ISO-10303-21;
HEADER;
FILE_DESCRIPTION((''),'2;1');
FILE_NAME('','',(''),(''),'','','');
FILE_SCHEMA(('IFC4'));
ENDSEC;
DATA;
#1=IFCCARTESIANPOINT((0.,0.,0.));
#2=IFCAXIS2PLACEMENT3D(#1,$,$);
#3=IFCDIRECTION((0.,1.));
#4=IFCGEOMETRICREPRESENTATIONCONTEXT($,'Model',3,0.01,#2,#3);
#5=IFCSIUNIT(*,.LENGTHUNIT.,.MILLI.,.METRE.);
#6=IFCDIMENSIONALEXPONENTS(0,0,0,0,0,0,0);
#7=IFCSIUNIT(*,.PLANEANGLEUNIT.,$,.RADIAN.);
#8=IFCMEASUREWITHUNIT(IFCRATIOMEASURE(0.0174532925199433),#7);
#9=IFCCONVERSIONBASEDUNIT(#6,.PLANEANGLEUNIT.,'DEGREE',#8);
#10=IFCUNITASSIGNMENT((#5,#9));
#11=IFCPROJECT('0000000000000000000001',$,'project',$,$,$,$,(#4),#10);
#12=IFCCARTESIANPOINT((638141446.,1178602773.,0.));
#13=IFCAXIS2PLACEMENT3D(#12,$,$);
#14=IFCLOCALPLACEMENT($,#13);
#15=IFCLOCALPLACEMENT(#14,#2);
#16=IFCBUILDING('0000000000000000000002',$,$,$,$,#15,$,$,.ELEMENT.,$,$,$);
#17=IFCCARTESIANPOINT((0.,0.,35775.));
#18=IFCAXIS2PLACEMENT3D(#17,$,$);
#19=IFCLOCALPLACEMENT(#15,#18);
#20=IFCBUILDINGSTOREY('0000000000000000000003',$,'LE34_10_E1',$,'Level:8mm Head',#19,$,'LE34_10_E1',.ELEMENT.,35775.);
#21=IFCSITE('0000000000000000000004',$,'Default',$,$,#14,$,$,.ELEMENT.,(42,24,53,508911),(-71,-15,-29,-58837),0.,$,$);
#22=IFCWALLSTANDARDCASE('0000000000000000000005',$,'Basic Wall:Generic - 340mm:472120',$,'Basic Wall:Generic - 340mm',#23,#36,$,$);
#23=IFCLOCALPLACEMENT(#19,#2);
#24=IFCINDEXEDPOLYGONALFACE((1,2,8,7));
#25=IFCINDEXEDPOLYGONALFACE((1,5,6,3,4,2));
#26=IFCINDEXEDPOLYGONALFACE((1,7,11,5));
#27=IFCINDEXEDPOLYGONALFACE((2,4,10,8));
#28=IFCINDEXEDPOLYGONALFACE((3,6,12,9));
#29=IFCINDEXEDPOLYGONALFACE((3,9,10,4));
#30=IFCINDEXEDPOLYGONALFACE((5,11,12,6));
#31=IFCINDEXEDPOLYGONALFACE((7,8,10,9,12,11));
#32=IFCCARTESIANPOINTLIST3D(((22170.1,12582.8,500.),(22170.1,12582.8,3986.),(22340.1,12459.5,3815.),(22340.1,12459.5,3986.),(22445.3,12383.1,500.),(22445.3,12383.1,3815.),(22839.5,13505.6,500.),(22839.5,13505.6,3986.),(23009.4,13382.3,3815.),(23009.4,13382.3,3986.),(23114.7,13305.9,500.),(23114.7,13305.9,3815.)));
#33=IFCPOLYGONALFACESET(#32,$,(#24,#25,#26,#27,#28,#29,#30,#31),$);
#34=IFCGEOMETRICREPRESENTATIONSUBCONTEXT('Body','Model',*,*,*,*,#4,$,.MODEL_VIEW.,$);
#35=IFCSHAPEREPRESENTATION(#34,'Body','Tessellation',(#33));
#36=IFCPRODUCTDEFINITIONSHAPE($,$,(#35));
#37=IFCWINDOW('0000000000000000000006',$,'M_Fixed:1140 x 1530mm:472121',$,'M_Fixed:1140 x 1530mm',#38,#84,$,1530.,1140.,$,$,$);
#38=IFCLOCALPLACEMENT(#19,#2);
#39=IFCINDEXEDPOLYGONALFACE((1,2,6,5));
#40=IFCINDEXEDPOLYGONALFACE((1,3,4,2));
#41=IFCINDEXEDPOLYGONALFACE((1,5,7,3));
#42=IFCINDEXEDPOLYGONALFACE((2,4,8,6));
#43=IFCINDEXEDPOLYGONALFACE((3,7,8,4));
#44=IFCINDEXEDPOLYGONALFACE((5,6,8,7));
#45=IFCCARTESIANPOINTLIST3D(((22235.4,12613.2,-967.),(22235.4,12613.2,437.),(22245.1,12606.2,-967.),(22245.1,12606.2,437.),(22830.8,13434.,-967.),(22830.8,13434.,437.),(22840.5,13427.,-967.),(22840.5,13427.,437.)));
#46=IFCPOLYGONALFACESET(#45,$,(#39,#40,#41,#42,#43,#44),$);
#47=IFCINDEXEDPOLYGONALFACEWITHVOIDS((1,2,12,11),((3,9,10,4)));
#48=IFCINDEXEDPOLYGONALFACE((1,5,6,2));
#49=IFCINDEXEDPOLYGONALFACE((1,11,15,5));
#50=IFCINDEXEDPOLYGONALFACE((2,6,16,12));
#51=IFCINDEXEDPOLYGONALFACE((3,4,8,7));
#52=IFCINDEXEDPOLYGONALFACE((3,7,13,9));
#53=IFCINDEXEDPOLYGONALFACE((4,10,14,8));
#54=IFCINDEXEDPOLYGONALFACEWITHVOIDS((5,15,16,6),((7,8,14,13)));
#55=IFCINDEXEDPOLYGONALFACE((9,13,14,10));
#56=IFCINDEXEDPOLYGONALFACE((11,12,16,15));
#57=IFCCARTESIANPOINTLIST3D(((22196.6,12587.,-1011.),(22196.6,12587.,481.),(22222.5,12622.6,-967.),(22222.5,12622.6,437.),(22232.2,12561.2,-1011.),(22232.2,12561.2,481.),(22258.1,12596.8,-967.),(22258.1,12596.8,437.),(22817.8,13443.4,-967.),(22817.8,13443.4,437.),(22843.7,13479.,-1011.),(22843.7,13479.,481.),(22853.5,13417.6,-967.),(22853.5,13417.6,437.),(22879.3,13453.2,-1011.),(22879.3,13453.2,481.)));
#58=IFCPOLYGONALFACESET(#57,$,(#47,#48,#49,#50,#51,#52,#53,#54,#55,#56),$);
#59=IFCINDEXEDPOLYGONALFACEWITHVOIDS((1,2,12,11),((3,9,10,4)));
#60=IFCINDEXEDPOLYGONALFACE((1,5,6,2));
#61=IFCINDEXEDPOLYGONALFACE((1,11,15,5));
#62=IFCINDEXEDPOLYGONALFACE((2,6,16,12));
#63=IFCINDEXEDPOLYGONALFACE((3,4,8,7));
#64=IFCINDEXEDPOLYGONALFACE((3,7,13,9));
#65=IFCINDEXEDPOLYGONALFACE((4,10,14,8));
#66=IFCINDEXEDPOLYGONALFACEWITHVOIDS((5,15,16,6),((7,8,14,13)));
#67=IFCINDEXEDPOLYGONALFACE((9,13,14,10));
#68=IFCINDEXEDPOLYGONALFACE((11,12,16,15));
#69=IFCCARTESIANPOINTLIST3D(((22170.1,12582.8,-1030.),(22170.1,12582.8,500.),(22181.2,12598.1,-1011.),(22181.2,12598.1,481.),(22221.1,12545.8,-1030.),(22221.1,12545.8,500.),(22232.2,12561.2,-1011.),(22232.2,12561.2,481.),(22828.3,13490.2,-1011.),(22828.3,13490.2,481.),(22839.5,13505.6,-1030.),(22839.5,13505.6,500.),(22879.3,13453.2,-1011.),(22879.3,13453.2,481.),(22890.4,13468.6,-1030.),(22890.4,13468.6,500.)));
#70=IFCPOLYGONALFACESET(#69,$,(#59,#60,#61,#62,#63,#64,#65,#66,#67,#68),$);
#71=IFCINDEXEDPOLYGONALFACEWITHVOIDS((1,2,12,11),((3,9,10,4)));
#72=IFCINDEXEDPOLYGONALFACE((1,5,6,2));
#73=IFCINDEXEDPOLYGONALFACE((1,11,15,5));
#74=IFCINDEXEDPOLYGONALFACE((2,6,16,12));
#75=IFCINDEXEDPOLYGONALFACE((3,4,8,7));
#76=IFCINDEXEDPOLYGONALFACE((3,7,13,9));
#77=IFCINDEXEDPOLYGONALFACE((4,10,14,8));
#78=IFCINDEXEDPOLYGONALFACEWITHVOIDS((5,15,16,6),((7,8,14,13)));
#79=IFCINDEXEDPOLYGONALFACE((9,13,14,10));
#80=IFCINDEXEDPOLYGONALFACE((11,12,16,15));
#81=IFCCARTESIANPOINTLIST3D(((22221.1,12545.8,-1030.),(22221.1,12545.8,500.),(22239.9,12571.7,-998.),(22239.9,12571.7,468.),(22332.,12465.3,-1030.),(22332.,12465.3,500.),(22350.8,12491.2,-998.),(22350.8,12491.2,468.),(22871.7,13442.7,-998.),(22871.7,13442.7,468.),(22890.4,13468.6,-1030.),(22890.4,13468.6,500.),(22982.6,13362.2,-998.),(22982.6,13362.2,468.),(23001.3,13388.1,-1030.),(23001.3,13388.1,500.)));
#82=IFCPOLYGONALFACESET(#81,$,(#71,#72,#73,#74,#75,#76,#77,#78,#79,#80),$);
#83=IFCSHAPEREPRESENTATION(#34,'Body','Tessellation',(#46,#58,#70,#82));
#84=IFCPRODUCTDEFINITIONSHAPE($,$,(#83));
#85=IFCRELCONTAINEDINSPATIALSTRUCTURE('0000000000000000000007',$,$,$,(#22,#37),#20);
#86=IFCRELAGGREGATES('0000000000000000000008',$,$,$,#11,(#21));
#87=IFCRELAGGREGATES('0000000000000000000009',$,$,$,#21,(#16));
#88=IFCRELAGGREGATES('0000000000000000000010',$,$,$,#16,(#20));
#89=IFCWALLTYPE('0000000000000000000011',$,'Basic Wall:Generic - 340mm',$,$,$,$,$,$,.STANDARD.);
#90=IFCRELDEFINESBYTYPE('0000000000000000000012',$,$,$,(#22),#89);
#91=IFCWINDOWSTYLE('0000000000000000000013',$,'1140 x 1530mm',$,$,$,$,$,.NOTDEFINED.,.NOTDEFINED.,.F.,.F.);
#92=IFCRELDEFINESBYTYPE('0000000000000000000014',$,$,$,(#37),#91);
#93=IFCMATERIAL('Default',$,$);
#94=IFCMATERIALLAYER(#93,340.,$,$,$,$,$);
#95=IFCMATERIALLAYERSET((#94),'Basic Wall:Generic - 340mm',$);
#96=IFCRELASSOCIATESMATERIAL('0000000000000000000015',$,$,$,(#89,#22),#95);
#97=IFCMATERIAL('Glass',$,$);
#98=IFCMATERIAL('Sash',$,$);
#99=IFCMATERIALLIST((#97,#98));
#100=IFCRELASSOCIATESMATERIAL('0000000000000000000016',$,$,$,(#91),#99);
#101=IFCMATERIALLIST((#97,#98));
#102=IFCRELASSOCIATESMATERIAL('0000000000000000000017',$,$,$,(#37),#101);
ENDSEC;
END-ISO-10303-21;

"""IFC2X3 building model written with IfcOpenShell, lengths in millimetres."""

from ifc_helpers import new_model, entity, si_unit, converted_unit, direction, frame, frame_2d, origin, place, context, subcontext, project, spatial, polyline, rectangle, outline, extrude, clip, bounded_halfspace, source, transform, mapped, material, material_list, layer, layer_set, layer_usage, type_object, type_shapes, element, fill, save


model = new_model("IFC2X3")

# Units and contexts
model_context = context("Model", 3, precision=0.01, world=origin(), true_north=direction((0.0, 1.0)))
body_context = subcontext(model_context, "Body", "Model", "MODEL_VIEW")
ifc_project = project(units=[si_unit("LENGTHUNIT", "METRE", prefix="MILLI"), converted_unit("PLANEANGLEUNIT", "DEGREE", entity("IfcRatioMeasure", 0.0174532925199433), si_unit("PLANEANGLEUNIT", "RADIAN"), dimensions=[0, 0, 0, 0, 0, 0, 0])], contexts=[model_context])

# Site, building, storey
site_placement = place(None, frame((638141446.0, 1178602773.0, 0.0)))
site = spatial("IfcSite", under=ifc_project, at=site_placement, Name="Default", CompositionType="ELEMENT", RefLatitude=(42, 24, 53, 508911), RefLongitude=(-71, -15, -29, -58837), RefElevation=0.0)
building_placement = place(site_placement, origin())
building = spatial("IfcBuilding", under=site, at=building_placement, CompositionType="ELEMENT")
storey_placement = place(building_placement, frame((0.0, 0.0, 35775.0)))
storey = spatial("IfcBuildingStorey", under=building, at=storey_placement, Name="LE34_10_E1", ObjectType="Level:8mm Head", LongName="LE34_10_E1", CompositionType="ELEMENT", Elevation=35775.0)

# Shared definitions
ifc_material_1 = material(Name="Default")

# Shared definitions
ifc_material_2 = material(Name="Glass")
ifc_material_3 = material(Name="Sash")

# Wall, opening, window
ifc_layer_1 = layer(ifc_material_1, 340.0)
ifc_layer_set_1 = layer_set([ifc_layer_1], Name="Basic Wall:Generic - 340mm")
wall_type_1 = type_object("IfcWallType", Name="Basic Wall:Generic - 340mm", PredefinedType="STANDARD", material=ifc_layer_set_1)
ifc_layer_usage_1 = layer_usage(ifc_layer_set_1, "AXIS2", "NEGATIVE", 170.0)
wall_1_placement = place(storey_placement, frame((22307.7, 12482.9, 500.0), z_axis=(0.0, 0.0, 1.0), x_axis=(0.587164, 0.809468, 0.0)))
wall_1 = element("IfcWallStandardCase", 1, at=wall_1_placement, inside=storey, type_object=wall_type_1, material=ifc_layer_usage_1, Name="Basic Wall:Generic - 340mm:472120", ObjectType="Basic Wall:Generic - 340mm", context=body_context, shape_type="Clipping", body=[
    clip(clip(extrude(rectangle(XDim=1140.0, YDim=340.0, at=frame_2d((570.0, 0.0), x_axis=(-1.0, 0.0))), origin(), (0.0, 0.0, 1.0), 3486.0), bounded_halfspace(frame((1140.0, -40.0, 3315.0), z_axis=(0.0, 0.0, 1.0), x_axis=(-1.0, 0.0, 0.0)), False, frame((1140.0, -40.0, 3315.0), z_axis=(0.0, 0.0, 1.0), x_axis=(-1.0, 0.0, 0.0)), polyline([(0.0, 0.0), (1140.0, 0.0), (1140.0, 130.0), (0.0, 130.0), (0.0, 0.0)]))), bounded_halfspace(frame((0.0, -40.0, 3315.0), z_axis=(0.0, 1.0, 0.0), x_axis=(-1.0, 0.0, 0.0)), True, frame((0.0, -40.0, 3315.0), z_axis=(0.0, 1.0, 0.0), x_axis=(-1.0, 0.0, 0.0)), polyline([(0.0, 0.0), (0.0, 171.0), (-1140.0, 171.0), (-1140.0, 0.0), (0.0, 0.0)]))),
])
opening_1_placement = place(wall_1_placement, frame((0.0, -170.0, -1530.0)))
opening_1 = element("IfcOpeningElement", 2, at=opening_1_placement, cuts=wall_1, ObjectType="Opening", context=body_context, shape_type="SweptSolid", body=[
    extrude(rectangle(XDim=1530.0, YDim=1140.0, at=frame_2d((765.0, 570.0), x_axis=(1.0, 0.0))), frame((0.0, 0.0, 0.0), z_axis=(0.0, 1.0, 0.0), x_axis=(0.0, 0.0, 1.0)), (0.0, 0.0, 1.0), 340.0),
])
ifc_material_list_1 = material_list([ifc_material_2, ifc_material_3])
ifc_material_list_2 = material_list([ifc_material_2, ifc_material_3])
window_style_1 = type_object("IfcWindowStyle", Name="1140 x 1530mm", ConstructionType="NOTDEFINED", OperationType="NOTDEFINED", ParameterTakesPrecedence=False, Sizeable=False, material=ifc_material_list_2)
shared_shape_1 = source(origin(), body_context, "Body", "SweptSolid", [
    extrude(rectangle(XDim=12.0, YDim=1014.0, at=frame_2d((0.0, 0.0), x_axis=(1.0, 0.0))), frame((570.0, 299.0, 63.0), z_axis=(0.0, 0.0, 1.0), x_axis=(0.0, -1.0, 0.0)), (0.0, 0.0, 1.0), 1404.0),
    extrude(outline(polyline([(-551.0, -746.0), (551.0, -746.0), (551.0, 746.0), (-551.0, 746.0), (-551.0, -746.0)]), holes=[polyline([(-507.0, -702.0), (-507.0, 702.0), (507.0, 702.0), (507.0, -702.0), (-507.0, -702.0)])]), frame((570.0, 277.0, 765.0), z_axis=(0.0, 1.0, 0.0), x_axis=(1.0, 0.0, 0.0)), (0.0, 0.0, 1.0), 44.0),
    extrude(outline(polyline([(-570.0, -765.0), (570.0, -765.0), (570.0, 765.0), (-570.0, 765.0), (-570.0, -765.0)]), holes=[polyline([(-551.0, -746.0), (-551.0, 746.0), (551.0, 746.0), (551.0, -746.0), (-551.0, -746.0)])]), frame((570.0, 277.0, 765.0), z_axis=(0.0, 1.0, 0.0), x_axis=(1.0, 0.0, 0.0)), (0.0, 0.0, 1.0), 63.0),
    extrude(outline(polyline([(-570.0, -765.0), (570.0, -765.0), (570.0, 765.0), (-570.0, 765.0), (-570.0, -765.0)]), holes=[polyline([(-538.0, -733.0), (-538.0, 733.0), (538.0, 733.0), (538.0, -733.0), (-538.0, -733.0)])]), frame((570.0, 140.0, 765.0), z_axis=(0.0, 1.0, 0.0), x_axis=(1.0, 0.0, 0.0)), (0.0, 0.0, 1.0), 137.0),
])
type_shapes(window_style_1, [shared_shape_1])
window_1_placement = place(opening_1_placement, origin())
window_1 = element("IfcWindow", 3, at=window_1_placement, inside=storey, type_object=window_style_1, material=ifc_material_list_1, Name="M_Fixed:1140 x 1530mm:472121", ObjectType="M_Fixed:1140 x 1530mm", OverallHeight=1530.0, OverallWidth=1140.0, context=body_context, shape_type="MappedRepresentation", body=[
    mapped(shared_shape_1, transform((0.0, 0.0, 0.0), scale=1.0)),
])
fill(opening_1, window_1)

save(model, "model.ifc")
